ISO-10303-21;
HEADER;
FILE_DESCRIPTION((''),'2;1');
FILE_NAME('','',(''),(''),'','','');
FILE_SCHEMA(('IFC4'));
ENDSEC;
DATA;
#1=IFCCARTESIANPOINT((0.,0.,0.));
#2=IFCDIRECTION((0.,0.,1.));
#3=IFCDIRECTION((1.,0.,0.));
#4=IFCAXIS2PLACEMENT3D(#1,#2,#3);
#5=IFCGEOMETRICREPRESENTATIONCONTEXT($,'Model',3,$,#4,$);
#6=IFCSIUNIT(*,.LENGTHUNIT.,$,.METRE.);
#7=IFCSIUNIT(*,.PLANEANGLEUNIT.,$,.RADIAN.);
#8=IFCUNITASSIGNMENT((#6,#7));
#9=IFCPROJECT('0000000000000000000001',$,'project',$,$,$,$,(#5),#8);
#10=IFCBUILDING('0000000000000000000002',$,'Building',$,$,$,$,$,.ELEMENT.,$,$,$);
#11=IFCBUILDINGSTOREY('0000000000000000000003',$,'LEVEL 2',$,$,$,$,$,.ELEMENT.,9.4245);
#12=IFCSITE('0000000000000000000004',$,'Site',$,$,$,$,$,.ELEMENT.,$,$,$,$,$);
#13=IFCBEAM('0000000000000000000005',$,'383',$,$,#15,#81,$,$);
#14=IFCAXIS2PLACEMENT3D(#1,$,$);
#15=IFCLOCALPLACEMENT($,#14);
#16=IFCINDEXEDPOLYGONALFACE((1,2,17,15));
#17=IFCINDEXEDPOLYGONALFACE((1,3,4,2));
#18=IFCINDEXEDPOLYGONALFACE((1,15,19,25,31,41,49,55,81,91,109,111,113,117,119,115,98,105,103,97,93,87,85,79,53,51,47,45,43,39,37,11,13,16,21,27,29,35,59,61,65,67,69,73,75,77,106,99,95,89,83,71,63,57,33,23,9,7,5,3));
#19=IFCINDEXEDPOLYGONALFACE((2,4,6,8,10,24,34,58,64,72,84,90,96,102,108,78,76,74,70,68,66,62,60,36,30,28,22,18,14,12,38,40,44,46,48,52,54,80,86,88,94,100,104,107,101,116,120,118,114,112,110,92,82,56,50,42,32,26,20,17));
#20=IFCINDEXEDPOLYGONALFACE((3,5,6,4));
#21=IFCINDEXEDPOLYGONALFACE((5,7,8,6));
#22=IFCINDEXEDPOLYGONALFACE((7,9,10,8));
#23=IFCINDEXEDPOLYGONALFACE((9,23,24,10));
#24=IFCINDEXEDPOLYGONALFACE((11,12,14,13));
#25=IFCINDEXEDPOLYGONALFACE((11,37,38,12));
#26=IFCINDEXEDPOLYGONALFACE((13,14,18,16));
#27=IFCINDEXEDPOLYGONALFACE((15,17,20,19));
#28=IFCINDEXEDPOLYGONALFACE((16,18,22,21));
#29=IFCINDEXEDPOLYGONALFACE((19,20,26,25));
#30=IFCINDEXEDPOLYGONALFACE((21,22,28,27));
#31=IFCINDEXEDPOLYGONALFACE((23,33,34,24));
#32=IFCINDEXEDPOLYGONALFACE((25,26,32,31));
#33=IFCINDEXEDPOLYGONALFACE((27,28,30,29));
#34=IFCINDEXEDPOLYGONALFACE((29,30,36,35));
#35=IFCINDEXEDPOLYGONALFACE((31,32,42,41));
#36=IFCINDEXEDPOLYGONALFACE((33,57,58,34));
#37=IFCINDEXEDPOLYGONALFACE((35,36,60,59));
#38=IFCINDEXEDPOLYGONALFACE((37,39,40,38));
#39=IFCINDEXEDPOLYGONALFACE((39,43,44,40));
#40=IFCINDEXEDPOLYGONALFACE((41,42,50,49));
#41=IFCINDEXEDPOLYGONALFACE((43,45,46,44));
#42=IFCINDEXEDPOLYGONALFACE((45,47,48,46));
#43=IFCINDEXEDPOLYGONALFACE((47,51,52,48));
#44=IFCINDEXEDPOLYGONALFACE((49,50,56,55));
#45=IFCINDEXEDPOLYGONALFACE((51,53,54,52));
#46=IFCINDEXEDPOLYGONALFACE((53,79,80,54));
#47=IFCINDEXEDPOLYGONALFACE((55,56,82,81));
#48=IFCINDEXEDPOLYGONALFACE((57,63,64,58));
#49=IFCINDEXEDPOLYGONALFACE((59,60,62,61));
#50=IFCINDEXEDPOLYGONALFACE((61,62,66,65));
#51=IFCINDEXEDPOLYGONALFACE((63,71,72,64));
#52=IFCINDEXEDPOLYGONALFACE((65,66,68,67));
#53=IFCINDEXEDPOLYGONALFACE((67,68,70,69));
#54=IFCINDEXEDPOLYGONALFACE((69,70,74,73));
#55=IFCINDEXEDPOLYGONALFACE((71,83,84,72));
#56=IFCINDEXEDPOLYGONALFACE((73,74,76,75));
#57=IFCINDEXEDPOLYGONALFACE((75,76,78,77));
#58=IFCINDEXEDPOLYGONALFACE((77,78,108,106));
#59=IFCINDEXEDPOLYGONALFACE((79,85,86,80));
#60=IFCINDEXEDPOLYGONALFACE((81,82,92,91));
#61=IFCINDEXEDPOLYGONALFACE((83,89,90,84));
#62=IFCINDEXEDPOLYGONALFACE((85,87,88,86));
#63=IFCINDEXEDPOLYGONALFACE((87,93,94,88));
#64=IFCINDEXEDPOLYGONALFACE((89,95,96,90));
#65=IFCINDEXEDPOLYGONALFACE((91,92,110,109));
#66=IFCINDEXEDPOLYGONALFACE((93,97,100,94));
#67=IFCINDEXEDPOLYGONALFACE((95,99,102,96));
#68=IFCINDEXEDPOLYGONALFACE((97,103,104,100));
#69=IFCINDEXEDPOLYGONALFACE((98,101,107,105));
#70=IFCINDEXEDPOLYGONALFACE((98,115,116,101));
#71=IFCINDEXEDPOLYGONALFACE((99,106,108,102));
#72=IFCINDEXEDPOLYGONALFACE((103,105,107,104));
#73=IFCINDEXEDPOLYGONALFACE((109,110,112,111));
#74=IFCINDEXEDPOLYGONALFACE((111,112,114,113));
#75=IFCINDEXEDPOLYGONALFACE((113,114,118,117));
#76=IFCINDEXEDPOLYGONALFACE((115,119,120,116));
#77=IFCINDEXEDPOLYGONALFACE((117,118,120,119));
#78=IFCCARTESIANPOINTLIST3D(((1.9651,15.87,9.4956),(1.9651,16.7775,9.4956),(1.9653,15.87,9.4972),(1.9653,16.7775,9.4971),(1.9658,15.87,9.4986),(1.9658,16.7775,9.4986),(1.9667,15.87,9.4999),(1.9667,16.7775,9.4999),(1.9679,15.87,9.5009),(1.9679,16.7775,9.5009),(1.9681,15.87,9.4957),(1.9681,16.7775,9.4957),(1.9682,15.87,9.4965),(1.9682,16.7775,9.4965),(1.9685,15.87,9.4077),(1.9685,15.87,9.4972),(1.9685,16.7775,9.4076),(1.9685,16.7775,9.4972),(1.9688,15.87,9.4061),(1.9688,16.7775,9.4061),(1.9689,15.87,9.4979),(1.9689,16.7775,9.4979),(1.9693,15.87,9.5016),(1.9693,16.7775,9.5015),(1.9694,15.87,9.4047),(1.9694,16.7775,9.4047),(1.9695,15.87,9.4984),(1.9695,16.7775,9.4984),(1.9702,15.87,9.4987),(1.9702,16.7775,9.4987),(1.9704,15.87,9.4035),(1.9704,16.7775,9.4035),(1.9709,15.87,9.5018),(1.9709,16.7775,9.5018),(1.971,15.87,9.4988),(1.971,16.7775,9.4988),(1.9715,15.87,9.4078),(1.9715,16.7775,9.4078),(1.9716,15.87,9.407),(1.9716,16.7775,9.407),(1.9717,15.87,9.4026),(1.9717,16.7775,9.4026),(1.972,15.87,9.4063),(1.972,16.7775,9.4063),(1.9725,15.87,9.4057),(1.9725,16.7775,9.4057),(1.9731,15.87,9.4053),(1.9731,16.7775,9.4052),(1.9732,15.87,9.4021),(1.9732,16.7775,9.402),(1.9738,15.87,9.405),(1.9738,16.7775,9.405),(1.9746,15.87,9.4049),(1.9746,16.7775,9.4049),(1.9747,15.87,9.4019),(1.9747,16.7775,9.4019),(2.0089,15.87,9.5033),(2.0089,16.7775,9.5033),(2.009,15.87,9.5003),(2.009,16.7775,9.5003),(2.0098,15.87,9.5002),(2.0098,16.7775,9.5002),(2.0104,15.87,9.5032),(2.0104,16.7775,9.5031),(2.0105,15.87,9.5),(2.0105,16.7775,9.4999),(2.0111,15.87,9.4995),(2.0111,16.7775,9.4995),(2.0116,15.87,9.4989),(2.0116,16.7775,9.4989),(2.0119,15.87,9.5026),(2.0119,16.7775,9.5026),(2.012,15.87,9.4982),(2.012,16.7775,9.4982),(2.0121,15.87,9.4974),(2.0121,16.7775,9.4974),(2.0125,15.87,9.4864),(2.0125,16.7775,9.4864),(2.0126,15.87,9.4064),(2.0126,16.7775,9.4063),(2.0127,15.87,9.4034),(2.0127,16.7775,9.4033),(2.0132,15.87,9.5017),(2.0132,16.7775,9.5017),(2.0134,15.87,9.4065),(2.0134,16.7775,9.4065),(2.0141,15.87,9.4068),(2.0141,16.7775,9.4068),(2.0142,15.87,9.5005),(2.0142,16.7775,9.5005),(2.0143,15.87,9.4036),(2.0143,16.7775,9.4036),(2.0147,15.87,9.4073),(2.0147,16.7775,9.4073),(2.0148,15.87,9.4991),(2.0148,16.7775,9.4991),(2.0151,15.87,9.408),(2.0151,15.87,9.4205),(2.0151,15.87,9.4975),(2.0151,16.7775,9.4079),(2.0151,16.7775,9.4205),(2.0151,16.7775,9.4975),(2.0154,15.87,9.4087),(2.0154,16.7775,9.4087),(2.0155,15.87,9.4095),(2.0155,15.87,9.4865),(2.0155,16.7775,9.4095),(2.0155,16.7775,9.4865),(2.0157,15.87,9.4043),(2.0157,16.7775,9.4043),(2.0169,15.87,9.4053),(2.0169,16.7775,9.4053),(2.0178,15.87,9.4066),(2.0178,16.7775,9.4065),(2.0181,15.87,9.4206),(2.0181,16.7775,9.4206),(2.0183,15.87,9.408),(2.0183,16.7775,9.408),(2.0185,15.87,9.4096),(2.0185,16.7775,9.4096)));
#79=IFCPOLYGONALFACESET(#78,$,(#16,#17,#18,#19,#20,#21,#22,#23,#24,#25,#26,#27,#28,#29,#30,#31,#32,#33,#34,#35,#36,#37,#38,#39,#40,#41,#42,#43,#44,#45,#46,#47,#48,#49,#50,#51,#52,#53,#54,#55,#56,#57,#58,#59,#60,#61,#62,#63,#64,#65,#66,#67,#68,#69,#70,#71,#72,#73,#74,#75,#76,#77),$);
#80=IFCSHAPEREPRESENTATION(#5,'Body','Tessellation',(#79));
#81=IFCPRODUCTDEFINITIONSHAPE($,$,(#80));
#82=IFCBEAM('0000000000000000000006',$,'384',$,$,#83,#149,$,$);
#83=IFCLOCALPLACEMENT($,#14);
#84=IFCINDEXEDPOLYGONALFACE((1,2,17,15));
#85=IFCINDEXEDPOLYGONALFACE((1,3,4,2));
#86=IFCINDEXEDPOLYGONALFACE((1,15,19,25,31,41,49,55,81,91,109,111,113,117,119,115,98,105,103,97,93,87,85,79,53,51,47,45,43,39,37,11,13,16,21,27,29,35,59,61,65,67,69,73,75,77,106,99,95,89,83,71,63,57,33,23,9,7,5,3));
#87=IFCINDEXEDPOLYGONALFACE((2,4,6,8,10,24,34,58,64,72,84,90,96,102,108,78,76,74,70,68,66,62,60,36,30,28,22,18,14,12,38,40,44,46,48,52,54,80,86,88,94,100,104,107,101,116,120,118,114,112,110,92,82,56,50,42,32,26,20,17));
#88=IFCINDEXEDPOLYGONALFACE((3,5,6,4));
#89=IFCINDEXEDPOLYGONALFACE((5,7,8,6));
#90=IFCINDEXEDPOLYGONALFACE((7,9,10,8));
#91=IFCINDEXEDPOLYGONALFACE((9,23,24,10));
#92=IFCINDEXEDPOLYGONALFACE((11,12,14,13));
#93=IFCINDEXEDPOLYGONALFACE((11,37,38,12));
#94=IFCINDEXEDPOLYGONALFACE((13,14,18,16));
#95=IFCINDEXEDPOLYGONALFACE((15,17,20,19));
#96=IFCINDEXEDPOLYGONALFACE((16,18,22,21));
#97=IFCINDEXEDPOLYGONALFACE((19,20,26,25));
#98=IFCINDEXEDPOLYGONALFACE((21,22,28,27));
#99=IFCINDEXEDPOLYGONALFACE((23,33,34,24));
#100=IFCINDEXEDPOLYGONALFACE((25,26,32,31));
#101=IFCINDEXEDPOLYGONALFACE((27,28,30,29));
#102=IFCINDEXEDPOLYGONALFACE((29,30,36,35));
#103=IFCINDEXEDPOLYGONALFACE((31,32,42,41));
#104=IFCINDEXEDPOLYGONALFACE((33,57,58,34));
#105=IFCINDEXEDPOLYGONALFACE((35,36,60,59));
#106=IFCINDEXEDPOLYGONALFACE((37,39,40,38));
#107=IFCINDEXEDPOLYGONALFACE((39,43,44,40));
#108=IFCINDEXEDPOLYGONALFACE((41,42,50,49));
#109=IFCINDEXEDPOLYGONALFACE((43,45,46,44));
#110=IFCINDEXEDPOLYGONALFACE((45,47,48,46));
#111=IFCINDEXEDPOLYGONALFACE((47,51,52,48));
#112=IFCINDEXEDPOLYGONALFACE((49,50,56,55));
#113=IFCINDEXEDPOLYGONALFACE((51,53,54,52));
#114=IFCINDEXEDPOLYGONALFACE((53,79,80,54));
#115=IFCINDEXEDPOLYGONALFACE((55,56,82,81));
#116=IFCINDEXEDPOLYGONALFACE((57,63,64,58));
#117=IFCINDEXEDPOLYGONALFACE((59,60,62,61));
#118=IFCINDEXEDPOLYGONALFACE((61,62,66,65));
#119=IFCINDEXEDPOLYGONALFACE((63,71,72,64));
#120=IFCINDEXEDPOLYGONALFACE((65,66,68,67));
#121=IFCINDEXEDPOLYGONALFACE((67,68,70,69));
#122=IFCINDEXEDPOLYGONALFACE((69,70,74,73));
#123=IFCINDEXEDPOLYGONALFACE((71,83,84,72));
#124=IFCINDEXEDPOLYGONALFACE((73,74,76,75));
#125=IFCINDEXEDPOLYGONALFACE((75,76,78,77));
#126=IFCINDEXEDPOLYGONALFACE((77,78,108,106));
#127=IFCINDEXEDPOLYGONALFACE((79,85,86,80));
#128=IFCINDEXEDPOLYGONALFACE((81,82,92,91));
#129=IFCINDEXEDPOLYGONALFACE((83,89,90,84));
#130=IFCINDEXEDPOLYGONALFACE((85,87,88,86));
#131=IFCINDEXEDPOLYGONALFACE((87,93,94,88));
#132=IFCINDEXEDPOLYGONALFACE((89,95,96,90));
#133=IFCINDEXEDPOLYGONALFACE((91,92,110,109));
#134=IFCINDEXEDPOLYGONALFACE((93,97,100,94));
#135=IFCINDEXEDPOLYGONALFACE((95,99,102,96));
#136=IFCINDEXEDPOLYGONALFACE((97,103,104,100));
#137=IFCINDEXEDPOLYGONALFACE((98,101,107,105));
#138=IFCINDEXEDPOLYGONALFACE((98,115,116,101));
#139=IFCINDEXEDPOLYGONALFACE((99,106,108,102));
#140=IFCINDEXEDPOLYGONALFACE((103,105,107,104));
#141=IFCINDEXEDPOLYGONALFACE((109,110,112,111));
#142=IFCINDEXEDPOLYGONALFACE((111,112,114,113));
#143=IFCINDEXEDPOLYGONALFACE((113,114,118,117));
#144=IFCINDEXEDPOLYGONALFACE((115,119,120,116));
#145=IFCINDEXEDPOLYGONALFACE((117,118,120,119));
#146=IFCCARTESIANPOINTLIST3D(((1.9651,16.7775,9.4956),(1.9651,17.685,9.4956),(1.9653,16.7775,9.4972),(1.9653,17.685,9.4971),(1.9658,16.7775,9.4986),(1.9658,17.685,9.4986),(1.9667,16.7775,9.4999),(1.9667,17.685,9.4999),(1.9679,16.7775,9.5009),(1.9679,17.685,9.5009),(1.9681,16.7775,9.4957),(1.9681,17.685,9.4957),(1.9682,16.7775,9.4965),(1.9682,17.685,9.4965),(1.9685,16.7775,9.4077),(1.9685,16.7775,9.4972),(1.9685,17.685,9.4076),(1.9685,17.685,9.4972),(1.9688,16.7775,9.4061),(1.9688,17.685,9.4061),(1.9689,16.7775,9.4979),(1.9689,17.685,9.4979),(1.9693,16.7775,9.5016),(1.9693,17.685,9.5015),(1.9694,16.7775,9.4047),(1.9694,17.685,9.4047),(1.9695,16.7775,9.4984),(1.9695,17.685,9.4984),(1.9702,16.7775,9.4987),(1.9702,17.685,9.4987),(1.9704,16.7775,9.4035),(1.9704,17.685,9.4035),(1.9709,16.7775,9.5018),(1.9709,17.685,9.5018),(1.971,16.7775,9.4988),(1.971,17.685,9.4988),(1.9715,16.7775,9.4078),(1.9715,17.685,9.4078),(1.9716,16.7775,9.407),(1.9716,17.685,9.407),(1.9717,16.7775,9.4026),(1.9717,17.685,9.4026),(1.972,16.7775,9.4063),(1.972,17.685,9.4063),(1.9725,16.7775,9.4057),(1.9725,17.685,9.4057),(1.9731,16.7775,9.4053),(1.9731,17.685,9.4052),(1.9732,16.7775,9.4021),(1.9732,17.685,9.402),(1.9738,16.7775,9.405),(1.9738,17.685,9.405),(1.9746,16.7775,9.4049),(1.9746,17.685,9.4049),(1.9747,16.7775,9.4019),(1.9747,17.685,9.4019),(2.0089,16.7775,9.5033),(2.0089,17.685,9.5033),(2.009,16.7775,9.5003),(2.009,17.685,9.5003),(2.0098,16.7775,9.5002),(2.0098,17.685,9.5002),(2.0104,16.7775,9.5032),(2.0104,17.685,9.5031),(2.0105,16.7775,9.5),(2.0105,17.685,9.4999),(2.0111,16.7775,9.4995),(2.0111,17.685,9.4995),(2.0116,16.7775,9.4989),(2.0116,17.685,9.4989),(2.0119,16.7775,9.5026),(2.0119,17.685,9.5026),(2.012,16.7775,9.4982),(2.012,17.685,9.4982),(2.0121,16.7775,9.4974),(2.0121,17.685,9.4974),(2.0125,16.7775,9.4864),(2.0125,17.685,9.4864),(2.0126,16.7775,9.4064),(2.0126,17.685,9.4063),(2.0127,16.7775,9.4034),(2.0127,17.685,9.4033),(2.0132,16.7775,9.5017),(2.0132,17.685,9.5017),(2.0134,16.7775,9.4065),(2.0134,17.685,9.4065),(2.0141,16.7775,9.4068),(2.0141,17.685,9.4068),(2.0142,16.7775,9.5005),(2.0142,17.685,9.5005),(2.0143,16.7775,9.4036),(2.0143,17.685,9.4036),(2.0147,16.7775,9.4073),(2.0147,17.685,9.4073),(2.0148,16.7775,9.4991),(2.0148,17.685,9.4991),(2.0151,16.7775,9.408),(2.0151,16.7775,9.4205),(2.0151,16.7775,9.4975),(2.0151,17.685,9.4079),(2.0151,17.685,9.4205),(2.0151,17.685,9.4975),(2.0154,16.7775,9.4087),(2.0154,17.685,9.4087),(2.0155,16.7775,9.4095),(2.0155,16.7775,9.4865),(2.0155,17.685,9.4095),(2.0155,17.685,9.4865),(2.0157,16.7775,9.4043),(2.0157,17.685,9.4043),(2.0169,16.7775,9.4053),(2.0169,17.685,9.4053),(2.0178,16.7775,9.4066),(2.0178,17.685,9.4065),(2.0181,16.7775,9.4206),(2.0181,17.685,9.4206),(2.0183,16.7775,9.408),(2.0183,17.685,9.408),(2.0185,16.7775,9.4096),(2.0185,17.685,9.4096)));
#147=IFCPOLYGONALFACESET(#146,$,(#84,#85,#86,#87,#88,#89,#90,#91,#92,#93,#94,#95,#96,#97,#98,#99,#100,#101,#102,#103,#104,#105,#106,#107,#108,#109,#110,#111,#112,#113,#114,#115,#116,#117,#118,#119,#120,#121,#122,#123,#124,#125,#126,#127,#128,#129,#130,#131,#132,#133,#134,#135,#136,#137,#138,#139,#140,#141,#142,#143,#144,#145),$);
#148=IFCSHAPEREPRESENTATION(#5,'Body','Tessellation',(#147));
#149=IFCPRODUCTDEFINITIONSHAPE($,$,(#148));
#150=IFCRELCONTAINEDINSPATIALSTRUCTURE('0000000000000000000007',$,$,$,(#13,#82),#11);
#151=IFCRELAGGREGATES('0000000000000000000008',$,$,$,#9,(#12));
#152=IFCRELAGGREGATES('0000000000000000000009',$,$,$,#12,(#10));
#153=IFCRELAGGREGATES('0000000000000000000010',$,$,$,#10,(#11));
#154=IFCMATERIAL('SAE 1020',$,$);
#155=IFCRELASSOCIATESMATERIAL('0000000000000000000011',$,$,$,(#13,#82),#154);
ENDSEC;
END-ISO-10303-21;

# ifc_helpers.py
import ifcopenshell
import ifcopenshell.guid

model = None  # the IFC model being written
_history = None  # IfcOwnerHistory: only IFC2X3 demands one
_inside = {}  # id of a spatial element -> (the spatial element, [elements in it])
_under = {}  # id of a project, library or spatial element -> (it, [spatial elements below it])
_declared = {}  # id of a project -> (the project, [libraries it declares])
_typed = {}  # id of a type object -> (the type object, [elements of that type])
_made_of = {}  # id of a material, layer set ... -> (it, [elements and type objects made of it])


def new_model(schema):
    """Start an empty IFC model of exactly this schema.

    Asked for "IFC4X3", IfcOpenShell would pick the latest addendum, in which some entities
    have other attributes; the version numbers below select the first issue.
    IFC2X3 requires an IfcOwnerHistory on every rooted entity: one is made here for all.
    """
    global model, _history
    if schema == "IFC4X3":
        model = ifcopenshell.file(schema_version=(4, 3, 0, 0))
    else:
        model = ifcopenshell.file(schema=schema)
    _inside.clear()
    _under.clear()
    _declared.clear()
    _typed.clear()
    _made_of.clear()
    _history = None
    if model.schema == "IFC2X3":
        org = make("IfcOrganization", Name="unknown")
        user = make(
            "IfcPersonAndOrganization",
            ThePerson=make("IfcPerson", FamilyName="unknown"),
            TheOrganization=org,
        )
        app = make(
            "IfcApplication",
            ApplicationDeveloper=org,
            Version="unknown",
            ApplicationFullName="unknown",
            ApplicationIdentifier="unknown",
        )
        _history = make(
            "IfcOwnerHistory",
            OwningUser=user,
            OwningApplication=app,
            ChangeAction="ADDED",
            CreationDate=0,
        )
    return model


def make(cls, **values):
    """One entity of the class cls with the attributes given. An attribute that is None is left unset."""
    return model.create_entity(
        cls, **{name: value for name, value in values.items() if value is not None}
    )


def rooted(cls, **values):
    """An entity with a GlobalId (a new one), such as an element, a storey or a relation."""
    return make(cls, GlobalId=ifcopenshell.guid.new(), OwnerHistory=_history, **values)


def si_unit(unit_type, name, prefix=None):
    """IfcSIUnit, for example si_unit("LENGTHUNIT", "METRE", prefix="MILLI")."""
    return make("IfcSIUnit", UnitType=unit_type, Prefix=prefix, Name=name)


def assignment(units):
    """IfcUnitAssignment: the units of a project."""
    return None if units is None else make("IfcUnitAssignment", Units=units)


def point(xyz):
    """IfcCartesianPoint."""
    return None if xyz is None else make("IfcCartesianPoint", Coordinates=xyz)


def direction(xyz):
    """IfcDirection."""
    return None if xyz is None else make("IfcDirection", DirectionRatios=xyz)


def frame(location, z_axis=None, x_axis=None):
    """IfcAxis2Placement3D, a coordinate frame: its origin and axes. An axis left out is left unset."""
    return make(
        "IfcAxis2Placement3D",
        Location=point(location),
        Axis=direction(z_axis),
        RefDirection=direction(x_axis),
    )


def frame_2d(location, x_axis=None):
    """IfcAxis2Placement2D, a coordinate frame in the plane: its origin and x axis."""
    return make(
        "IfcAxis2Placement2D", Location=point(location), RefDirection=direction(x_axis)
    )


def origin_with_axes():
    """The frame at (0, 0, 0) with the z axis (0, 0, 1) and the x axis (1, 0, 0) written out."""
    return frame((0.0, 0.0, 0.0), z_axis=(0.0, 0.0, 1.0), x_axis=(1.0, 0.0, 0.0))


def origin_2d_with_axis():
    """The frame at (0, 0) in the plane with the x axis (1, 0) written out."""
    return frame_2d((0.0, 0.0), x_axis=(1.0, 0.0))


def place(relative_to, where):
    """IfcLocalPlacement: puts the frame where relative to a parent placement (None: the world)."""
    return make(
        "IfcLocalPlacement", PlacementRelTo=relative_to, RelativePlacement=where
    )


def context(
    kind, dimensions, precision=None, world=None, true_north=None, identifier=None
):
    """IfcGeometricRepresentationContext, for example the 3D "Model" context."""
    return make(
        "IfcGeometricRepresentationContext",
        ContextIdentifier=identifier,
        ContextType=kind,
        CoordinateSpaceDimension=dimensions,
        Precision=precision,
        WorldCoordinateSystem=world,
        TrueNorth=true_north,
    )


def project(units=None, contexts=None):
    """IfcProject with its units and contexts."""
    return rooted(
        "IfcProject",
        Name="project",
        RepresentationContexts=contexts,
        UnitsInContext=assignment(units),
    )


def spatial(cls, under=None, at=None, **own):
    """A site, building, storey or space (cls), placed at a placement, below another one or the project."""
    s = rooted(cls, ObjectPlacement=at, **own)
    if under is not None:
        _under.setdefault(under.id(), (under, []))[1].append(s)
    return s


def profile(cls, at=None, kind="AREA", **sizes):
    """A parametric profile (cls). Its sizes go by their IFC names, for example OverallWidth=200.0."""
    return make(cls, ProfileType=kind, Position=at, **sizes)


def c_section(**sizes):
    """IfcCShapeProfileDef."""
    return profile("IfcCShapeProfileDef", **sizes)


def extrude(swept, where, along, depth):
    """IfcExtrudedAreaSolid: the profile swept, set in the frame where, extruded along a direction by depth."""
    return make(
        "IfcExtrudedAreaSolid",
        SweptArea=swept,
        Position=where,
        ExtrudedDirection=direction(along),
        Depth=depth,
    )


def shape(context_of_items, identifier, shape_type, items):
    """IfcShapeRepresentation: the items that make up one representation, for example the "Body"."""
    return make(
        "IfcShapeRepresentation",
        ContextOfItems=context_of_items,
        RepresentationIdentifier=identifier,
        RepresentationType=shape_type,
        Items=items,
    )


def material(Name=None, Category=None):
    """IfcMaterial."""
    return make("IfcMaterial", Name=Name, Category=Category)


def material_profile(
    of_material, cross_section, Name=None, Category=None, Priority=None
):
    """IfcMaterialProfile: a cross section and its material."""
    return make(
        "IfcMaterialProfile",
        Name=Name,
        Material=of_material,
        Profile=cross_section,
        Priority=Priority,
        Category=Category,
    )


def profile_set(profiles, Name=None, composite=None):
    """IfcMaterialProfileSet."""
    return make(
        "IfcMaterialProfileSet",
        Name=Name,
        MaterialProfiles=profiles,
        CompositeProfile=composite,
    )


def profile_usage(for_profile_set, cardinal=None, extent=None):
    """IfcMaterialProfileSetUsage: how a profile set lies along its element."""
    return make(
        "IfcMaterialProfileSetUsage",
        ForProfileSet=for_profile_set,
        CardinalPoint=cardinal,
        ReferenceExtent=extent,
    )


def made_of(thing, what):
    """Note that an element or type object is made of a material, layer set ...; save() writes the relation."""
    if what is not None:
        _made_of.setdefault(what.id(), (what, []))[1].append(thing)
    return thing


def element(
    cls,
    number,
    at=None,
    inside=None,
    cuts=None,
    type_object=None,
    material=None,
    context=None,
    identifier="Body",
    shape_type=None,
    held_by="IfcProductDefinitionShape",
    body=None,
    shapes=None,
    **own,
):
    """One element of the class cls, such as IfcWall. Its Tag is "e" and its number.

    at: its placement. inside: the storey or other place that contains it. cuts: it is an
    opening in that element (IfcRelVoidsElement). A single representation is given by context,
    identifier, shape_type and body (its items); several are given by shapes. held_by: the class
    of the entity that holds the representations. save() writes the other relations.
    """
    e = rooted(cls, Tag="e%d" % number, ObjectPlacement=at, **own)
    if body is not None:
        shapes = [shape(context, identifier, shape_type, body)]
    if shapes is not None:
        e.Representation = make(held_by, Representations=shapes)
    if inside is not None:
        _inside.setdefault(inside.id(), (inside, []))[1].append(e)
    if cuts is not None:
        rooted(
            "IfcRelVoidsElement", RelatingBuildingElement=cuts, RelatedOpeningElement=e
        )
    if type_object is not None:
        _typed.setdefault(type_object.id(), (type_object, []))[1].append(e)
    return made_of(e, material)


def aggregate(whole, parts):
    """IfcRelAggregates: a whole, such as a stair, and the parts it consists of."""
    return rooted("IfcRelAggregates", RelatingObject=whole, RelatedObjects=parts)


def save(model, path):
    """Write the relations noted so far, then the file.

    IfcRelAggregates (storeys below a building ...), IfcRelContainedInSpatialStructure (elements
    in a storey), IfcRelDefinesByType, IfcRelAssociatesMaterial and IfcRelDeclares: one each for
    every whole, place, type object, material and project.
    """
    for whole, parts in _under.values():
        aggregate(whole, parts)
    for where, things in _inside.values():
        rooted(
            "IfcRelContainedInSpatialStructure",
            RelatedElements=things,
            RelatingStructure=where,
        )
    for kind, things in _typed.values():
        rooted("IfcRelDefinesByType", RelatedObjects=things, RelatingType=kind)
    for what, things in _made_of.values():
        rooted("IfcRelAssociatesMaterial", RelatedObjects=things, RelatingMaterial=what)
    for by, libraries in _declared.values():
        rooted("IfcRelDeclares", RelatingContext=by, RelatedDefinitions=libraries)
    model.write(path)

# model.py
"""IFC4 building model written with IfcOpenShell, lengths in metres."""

from ifc_helpers import new_model, si_unit, frame, origin_with_axes, origin_2d_with_axis, place, context, project, spatial, c_section, extrude, material, material_profile, profile_set, profile_usage, element, save


model = new_model("IFC4")

# Units and contexts
model_context = context("Model", 3, world=origin_with_axes())
ifc_project = project(units=[si_unit("LENGTHUNIT", "METRE"), si_unit("PLANEANGLEUNIT", "RADIAN")], contexts=[model_context])

# Site, building, storey
site = spatial("IfcSite", under=ifc_project, Name="Site", CompositionType="ELEMENT")
building = spatial("IfcBuilding", under=site, Name="Building", CompositionType="ELEMENT")
storey = spatial("IfcBuildingStorey", under=building, Name="LEVEL 2", CompositionType="ELEMENT", Elevation=9.4245)

# Beams
ifc_material = material(Name="SAE 1020")
ifc_material_profile_1 = material_profile(ifc_material, c_section(Depth=0.1, Width=0.05, WallThickness=0.003, Girth=0.017, InternalFilletRadius=0.003, at=origin_2d_with_axis()))
ifc_profile_set_1 = profile_set([ifc_material_profile_1])
ifc_profile_usage_1 = profile_usage(ifc_profile_set_1, cardinal=10)
beam_1_placement = place(None, frame((1.9918, 15.87, 9.4526), z_axis=(0.0, 1.0, -0.00003), x_axis=(0.999256, 0.000001, 0.038562)))
element("IfcBeam", 1, at=beam_1_placement, inside=storey, material=ifc_profile_usage_1, Name="383", context=model_context, shape_type="SweptSolid", body=[
    extrude(c_section(Depth=0.1, Width=0.05, WallThickness=0.003, Girth=0.017, InternalFilletRadius=0.003, at=origin_2d_with_axis()), origin_with_axes(), (0.0, 0.0, 1.0), 0.9075),
])
ifc_material_profile_2 = material_profile(ifc_material, c_section(Depth=0.1, Width=0.05, WallThickness=0.003, Girth=0.017, InternalFilletRadius=0.003, at=origin_2d_with_axis()))
ifc_profile_set_2 = profile_set([ifc_material_profile_2])
ifc_profile_usage_2 = profile_usage(ifc_profile_set_2, cardinal=10)
beam_2_placement = place(None, frame((1.9918, 16.7775, 9.4526), z_axis=(0.0, 1.0, -0.00003), x_axis=(0.999256, 0.000001, 0.038562)))
element("IfcBeam", 2, at=beam_2_placement, inside=storey, material=ifc_profile_usage_2, Name="384", context=model_context, shape_type="SweptSolid", body=[
    extrude(c_section(Depth=0.1, Width=0.05, WallThickness=0.003, Girth=0.017, InternalFilletRadius=0.003, at=origin_2d_with_axis()), origin_with_axes(), (0.0, 0.0, 1.0), 0.9075),
])

save(model, "model.ifc")
